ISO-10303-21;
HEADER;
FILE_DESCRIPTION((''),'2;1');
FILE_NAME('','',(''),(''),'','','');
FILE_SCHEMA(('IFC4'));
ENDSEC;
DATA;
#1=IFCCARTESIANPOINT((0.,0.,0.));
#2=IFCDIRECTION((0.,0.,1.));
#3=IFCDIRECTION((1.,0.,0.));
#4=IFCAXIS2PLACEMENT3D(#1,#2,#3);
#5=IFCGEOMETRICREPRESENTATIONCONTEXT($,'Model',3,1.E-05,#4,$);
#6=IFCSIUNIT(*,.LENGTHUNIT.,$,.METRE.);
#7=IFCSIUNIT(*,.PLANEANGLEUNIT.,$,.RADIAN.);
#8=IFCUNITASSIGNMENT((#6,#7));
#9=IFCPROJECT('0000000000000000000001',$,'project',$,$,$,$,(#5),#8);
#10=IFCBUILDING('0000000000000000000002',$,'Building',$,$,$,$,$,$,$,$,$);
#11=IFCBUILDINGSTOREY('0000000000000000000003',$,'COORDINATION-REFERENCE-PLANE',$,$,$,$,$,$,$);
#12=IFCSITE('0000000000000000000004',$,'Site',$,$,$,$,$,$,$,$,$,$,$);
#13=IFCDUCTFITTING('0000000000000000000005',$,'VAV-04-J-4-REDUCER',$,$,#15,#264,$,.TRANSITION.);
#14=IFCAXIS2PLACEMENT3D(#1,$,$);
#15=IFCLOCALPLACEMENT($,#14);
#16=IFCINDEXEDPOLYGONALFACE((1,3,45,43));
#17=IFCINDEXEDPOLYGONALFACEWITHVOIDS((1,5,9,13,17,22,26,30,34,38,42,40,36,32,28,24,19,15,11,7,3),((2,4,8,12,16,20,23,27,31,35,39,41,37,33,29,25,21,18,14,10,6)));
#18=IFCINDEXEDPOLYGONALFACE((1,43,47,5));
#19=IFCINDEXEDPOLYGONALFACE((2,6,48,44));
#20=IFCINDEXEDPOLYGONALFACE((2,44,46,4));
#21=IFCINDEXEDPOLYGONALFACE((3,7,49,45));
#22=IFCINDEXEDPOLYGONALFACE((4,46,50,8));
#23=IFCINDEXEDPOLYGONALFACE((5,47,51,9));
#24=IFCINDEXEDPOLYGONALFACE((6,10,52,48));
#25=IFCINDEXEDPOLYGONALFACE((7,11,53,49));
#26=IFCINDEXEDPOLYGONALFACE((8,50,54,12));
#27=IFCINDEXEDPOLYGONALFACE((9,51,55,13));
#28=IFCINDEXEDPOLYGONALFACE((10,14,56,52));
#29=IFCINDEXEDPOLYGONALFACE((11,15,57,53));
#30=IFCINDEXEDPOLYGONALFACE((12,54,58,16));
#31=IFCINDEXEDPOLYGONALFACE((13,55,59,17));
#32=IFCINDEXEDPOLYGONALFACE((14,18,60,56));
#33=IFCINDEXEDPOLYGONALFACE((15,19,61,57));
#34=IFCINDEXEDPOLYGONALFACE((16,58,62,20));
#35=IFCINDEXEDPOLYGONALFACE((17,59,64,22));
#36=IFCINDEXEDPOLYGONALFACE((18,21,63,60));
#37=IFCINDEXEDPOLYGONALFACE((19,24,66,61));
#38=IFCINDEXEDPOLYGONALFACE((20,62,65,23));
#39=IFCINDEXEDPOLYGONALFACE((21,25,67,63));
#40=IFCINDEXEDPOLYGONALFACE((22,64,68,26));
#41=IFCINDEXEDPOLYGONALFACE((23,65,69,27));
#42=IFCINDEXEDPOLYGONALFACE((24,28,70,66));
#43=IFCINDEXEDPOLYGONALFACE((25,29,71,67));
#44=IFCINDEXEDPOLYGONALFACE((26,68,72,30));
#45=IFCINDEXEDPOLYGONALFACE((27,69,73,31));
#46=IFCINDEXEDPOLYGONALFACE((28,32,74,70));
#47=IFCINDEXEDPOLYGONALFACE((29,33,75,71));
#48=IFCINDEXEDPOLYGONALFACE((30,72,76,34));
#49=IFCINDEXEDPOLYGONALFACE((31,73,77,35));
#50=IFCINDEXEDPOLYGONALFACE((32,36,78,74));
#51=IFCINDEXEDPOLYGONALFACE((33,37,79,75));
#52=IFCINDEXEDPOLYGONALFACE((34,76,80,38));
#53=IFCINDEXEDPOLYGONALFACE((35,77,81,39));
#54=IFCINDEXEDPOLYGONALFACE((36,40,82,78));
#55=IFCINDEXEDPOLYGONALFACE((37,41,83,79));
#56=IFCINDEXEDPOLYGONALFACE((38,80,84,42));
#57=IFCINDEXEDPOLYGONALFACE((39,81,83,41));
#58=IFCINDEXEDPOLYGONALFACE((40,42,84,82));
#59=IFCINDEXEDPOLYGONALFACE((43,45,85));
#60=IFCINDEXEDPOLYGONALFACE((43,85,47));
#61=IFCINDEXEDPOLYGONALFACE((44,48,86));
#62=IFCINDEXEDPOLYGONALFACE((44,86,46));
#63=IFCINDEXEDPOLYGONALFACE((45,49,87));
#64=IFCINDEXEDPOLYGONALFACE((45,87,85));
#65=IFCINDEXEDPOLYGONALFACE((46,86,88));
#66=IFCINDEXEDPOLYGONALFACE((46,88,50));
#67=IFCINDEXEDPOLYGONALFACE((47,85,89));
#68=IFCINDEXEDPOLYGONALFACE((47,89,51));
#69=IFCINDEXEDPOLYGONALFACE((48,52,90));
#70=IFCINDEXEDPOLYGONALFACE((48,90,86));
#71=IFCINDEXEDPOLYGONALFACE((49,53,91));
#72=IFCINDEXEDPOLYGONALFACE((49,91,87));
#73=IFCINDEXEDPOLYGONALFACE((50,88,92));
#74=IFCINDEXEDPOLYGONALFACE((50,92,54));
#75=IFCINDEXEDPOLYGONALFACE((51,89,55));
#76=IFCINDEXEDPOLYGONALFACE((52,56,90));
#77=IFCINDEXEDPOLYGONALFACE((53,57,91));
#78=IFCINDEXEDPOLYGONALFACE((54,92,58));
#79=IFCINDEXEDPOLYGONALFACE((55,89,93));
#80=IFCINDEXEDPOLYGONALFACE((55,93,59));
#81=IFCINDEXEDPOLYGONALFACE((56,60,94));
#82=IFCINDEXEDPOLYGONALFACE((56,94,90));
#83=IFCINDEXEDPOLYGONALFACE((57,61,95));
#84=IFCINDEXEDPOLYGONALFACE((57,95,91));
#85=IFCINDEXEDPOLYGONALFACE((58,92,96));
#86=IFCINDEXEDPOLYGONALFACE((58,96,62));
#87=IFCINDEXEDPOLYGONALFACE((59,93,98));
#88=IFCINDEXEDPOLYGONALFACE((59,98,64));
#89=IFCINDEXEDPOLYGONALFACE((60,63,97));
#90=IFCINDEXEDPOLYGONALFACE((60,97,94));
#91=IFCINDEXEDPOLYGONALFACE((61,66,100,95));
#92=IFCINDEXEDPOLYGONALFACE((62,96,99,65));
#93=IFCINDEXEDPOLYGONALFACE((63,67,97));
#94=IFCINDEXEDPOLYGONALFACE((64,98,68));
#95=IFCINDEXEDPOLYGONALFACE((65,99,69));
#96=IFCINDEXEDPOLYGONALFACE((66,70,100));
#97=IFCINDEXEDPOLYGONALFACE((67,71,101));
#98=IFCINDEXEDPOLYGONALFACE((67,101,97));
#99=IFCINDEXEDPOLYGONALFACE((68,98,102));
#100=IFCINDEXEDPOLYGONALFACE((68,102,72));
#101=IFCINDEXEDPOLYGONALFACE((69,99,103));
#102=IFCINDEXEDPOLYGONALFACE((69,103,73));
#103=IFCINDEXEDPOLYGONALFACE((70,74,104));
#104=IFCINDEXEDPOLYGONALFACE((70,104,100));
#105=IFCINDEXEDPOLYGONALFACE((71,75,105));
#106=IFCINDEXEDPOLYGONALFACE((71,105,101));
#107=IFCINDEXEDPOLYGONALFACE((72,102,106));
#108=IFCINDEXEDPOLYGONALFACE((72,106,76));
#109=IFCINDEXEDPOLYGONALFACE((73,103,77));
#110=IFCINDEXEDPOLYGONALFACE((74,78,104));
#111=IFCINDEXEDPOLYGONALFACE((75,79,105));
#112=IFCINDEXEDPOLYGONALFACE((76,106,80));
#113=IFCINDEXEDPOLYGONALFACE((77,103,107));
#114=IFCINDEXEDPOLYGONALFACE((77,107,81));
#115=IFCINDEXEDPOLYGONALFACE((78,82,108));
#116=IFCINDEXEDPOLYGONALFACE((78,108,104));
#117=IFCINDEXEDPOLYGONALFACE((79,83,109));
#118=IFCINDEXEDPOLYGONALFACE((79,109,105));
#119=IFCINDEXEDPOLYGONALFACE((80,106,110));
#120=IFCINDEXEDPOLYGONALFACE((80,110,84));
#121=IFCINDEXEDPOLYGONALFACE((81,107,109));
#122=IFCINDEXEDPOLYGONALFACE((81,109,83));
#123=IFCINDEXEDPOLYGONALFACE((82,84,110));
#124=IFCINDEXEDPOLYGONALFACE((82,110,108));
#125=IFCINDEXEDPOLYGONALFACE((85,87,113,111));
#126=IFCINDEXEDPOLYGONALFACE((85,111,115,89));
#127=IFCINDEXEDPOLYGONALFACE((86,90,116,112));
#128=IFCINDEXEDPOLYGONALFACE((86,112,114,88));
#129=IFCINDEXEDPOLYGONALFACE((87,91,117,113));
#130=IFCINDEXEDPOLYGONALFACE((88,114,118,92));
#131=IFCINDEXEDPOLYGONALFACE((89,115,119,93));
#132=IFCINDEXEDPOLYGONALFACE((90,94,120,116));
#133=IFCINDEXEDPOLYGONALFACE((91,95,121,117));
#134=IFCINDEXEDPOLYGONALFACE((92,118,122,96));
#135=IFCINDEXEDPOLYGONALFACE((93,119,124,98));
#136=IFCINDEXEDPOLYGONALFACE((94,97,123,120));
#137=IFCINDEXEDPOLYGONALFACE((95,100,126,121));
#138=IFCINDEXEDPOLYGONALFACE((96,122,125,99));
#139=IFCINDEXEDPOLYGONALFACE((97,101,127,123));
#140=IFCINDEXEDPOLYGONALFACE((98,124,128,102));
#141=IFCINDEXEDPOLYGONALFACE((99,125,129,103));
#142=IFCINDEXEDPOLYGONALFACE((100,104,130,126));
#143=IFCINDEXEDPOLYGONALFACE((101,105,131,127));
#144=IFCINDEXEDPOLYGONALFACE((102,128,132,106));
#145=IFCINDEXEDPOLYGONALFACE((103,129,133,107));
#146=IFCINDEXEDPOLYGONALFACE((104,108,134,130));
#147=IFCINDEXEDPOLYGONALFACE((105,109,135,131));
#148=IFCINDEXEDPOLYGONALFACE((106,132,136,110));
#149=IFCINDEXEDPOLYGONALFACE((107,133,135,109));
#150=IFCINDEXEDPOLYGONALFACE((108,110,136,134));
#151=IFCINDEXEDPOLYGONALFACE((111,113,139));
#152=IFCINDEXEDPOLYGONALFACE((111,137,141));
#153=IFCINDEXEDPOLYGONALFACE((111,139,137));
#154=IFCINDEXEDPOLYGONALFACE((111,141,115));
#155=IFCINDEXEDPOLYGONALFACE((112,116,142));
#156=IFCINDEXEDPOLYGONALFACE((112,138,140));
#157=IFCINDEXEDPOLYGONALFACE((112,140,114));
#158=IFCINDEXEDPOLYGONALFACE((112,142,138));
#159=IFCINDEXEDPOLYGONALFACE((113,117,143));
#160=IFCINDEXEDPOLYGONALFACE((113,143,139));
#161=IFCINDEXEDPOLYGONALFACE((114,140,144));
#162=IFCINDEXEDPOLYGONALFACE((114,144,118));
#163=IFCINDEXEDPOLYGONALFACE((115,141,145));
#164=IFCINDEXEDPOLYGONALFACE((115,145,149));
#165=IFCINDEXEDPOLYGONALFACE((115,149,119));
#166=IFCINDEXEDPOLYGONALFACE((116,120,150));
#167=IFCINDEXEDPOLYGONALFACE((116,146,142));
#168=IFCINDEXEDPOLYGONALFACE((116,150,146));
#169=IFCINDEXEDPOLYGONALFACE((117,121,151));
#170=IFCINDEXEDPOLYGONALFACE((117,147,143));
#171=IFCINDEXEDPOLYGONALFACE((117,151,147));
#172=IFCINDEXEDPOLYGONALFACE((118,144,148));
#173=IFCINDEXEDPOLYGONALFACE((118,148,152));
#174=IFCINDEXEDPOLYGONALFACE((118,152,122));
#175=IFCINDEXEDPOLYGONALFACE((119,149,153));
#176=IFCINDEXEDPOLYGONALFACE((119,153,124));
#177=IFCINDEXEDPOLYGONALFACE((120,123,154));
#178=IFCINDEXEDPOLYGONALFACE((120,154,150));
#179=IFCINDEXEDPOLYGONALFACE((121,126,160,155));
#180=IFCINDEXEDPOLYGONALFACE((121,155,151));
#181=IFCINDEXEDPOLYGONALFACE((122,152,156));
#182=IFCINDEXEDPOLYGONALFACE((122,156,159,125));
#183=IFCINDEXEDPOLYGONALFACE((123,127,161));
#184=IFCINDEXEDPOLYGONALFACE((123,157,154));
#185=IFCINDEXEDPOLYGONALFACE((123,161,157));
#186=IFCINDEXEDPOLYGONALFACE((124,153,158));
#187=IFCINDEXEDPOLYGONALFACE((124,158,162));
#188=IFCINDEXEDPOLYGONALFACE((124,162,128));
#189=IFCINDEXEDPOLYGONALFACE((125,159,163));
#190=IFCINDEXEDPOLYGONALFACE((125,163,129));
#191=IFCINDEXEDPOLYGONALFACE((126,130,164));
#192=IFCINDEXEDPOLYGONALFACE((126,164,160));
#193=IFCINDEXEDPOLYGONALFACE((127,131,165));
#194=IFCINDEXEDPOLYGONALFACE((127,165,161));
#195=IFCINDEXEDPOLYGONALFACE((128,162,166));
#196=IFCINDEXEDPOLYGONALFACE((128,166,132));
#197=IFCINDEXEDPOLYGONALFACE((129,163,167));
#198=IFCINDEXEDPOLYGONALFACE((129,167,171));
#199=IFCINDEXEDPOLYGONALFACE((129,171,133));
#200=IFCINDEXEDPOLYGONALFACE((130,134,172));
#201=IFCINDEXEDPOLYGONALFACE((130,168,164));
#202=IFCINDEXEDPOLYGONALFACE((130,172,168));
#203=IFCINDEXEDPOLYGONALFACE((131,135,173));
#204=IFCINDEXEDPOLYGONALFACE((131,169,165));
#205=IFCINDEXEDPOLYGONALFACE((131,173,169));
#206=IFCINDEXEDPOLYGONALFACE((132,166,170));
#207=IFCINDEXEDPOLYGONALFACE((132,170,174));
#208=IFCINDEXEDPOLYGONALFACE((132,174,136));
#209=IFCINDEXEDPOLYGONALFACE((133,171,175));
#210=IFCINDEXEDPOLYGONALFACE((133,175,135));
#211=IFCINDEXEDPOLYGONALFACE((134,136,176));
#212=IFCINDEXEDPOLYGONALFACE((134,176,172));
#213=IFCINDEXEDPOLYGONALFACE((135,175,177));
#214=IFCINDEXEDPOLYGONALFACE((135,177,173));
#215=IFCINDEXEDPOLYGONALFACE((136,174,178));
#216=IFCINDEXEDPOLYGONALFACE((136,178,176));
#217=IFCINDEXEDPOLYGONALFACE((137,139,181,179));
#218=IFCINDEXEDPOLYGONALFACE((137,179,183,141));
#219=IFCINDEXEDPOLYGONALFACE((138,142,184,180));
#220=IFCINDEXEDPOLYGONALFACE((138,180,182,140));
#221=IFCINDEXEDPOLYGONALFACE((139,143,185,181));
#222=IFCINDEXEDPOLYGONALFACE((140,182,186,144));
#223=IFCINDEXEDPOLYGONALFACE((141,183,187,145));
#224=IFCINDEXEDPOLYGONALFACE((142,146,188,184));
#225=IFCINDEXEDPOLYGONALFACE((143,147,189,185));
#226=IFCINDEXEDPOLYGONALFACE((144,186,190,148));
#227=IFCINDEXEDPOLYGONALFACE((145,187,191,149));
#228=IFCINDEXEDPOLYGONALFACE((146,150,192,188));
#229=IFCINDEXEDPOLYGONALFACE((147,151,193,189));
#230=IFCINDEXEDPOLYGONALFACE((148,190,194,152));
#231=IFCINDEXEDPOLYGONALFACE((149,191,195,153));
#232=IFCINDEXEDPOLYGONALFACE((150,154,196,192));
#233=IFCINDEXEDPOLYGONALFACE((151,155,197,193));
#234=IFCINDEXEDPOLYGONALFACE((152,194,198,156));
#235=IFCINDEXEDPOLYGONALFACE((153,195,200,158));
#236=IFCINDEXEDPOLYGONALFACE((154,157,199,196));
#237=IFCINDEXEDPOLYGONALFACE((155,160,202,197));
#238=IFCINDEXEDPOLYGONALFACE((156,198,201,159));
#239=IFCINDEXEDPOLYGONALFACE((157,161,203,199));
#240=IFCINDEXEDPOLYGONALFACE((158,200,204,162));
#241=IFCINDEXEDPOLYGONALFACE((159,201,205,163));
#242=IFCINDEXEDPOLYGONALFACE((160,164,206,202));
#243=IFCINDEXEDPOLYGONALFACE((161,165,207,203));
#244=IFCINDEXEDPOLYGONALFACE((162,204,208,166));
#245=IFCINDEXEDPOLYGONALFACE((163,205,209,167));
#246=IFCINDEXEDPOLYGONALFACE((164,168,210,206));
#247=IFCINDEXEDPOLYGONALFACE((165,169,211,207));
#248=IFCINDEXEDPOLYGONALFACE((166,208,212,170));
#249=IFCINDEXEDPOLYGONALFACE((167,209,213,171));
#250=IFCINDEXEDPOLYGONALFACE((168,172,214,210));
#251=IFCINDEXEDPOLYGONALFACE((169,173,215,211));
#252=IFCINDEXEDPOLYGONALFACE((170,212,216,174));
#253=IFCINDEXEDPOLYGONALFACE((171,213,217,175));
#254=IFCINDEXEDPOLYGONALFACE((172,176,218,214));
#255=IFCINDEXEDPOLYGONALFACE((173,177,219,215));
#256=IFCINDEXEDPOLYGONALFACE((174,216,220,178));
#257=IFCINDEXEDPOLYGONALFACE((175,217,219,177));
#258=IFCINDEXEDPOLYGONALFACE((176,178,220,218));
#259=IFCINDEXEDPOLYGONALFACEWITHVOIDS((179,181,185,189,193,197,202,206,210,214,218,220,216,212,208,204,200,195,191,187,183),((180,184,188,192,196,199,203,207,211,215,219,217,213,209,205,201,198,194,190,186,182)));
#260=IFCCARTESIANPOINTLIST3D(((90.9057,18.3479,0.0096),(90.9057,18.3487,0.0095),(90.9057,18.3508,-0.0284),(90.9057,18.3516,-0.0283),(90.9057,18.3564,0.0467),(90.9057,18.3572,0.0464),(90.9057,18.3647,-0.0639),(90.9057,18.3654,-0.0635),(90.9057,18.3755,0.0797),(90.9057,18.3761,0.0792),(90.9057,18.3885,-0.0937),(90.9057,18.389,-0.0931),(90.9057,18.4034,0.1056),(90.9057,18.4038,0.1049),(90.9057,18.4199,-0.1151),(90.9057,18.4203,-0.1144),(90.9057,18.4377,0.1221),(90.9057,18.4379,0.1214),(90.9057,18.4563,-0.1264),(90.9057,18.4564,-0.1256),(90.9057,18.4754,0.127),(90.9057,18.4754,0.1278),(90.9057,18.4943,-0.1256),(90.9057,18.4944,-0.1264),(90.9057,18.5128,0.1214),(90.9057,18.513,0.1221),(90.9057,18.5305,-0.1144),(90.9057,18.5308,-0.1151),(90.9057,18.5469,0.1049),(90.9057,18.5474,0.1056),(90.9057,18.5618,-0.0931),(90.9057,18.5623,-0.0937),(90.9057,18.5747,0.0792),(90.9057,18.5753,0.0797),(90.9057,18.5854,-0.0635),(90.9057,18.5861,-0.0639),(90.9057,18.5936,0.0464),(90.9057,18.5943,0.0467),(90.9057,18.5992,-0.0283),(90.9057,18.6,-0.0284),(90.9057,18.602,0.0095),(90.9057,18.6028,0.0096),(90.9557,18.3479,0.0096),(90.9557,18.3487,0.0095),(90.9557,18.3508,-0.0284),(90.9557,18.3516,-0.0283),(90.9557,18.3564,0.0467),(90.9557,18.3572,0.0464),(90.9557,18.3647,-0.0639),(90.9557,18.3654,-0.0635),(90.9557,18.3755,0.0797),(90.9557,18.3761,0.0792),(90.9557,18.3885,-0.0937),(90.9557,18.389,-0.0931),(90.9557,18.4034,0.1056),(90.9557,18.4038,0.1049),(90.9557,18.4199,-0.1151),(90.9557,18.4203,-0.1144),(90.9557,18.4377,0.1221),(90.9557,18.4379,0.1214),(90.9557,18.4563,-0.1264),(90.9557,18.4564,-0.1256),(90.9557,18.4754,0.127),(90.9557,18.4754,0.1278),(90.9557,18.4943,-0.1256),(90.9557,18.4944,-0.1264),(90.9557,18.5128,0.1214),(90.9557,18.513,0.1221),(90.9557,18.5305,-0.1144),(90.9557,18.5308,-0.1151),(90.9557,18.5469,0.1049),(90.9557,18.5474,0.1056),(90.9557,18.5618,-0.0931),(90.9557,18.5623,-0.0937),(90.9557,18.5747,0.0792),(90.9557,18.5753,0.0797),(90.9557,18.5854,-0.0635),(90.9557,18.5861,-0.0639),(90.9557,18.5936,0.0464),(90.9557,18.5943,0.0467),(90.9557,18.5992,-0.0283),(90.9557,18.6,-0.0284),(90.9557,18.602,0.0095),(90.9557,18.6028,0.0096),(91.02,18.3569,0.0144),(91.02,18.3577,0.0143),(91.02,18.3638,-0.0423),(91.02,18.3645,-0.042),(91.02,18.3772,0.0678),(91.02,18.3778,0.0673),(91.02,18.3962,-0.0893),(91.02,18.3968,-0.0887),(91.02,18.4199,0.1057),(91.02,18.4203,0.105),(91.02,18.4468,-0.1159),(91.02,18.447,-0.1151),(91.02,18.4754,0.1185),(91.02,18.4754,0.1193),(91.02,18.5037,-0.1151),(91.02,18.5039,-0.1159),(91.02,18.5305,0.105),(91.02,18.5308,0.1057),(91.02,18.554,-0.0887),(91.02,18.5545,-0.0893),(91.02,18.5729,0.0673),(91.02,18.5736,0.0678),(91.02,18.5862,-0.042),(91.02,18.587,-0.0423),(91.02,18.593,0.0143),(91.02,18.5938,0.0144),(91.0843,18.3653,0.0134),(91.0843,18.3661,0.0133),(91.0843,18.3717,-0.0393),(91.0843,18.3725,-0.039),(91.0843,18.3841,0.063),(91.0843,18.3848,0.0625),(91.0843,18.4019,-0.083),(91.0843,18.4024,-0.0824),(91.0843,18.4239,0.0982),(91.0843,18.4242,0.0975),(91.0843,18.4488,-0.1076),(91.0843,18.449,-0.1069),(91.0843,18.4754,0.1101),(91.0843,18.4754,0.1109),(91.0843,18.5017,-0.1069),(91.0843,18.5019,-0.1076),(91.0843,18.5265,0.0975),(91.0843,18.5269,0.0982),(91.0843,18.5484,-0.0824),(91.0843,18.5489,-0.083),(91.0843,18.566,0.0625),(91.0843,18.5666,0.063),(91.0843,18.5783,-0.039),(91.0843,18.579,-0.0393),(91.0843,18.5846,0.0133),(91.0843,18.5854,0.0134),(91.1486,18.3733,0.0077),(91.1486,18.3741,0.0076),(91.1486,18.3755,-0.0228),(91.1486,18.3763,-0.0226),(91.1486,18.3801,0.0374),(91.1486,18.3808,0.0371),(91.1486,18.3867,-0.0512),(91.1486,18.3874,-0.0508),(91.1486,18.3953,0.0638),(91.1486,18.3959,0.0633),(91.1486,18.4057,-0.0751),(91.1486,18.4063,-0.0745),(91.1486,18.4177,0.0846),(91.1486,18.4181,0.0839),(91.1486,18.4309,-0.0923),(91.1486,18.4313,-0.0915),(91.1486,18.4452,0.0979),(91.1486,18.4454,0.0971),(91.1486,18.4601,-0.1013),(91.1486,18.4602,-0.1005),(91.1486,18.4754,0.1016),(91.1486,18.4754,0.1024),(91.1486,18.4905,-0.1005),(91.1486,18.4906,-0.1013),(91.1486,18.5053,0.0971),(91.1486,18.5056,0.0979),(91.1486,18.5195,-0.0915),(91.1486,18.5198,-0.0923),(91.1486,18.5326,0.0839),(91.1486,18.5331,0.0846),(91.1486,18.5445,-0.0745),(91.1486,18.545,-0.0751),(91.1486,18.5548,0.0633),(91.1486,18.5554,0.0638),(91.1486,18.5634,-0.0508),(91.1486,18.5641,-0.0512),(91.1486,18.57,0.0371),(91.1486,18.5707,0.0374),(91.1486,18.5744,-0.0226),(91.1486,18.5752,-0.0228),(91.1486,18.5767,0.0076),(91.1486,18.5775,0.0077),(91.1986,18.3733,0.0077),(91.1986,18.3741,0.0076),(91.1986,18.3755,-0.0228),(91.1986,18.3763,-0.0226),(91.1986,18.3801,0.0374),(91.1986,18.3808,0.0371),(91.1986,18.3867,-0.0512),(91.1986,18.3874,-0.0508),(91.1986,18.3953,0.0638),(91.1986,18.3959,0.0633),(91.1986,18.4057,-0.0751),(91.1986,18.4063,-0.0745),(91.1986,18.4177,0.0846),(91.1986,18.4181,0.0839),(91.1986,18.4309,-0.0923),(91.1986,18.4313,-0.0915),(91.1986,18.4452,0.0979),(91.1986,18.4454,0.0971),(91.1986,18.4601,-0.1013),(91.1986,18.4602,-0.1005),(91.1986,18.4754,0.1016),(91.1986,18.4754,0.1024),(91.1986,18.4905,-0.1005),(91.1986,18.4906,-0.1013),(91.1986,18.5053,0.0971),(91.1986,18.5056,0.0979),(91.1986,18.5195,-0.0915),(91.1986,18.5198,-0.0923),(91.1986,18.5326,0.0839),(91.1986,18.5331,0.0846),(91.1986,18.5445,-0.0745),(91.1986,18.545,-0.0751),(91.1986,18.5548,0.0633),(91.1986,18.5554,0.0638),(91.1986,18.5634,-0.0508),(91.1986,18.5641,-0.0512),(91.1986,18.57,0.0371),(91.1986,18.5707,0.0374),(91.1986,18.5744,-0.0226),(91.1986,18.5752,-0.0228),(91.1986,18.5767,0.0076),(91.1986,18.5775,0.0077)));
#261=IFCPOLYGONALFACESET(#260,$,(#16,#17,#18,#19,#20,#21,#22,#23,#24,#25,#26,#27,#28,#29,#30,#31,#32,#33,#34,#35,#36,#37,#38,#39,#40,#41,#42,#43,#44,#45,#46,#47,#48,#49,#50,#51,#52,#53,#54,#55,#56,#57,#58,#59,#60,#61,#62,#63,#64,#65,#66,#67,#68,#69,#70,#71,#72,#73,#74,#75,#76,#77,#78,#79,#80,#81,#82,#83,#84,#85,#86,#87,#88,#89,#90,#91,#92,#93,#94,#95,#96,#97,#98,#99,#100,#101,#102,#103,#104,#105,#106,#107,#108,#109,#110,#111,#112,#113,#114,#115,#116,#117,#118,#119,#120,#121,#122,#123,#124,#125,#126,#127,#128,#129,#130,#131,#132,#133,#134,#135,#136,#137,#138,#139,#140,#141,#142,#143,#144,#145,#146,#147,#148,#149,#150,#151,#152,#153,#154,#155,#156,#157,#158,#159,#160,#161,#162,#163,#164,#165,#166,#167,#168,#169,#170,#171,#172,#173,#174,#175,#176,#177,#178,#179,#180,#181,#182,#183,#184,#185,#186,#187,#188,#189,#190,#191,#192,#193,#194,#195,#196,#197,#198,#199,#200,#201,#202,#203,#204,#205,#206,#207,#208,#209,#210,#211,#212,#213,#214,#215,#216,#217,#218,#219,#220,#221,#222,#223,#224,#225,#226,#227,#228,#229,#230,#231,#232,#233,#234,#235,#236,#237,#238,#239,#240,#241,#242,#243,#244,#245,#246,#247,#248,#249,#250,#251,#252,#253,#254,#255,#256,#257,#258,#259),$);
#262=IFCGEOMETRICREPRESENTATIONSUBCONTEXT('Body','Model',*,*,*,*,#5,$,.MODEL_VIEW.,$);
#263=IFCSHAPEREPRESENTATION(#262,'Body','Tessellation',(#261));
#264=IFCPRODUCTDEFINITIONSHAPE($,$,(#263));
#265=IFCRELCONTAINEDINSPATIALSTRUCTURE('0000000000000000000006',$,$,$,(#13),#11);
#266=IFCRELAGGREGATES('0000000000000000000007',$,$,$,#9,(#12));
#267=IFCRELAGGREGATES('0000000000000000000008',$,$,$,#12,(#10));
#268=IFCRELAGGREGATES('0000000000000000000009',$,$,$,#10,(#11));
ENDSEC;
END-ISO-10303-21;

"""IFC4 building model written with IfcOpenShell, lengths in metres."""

from ifc_helpers import new_model, entity, si_unit, frame, origin_with_axes, place, context, subcontext, project, spatial, element, save


model = new_model("IFC4")

# Units and contexts
model_context_1 = context("Model", 3, precision=1e-05, world=origin_with_axes())
body_context_1 = subcontext(model_context_1, "Body", "Model", "MODEL_VIEW")
ifc_project = project(units=[si_unit("LENGTHUNIT", "METRE"), si_unit("PLANEANGLEUNIT", "RADIAN")], contexts=[model_context_1])

# Site, building, storey
site = spatial("IfcSite", under=ifc_project, Name="Site")
building = spatial("IfcBuilding", under=site, Name="Building")
storey = spatial("IfcBuildingStorey", under=building, Name="COORDINATION-REFERENCE-PLANE")

# Duct fitting
for number, where, z_axis, x_axis, name in (
    (1, (90.9057, 18.4754, 0.0), (0.0, 1.0, 0.0), (0.0, 0.0, 1.0), "VAV-04-J-4-REDUCER"),
):
    element("IfcDuctFitting", number, at=place(None, frame(where, z_axis=z_axis, x_axis=x_axis)), inside=storey, Name=name, PredefinedType="TRANSITION", context=body_context_1, shape_type="SweptSolid", body=[
        entity("IfcRevolvedAreaSolid", entity("IfcArbitraryClosedProfileDef", "AREA", None, entity("IfcPolyline", [entity("IfcCartesianPoint", [0.1278, 0.0]), entity("IfcCartesianPoint", [0.1278, 0.05]), entity("IfcCartesianPoint", [0.1024, 0.2429]), entity("IfcCartesianPoint", [0.1024, 0.2929]), entity("IfcCartesianPoint", [0.1016, 0.2929]), entity("IfcCartesianPoint", [0.1016, 0.2429]), entity("IfcCartesianPoint", [0.127, 0.05]), entity("IfcCartesianPoint", [0.127, 0.0]), entity("IfcCartesianPoint", [0.1278, 0.0])])), entity("IfcAxis2Placement3D", entity("IfcCartesianPoint", [0.0, 0.0, 0.0])), entity("IfcAxis1Placement", entity("IfcCartesianPoint", [0.0, 0.0, 0.0]), entity("IfcDirection", [0.0, 1.0, 0.0])), 6.283185),
    ])

save(model, "model.ifc")
